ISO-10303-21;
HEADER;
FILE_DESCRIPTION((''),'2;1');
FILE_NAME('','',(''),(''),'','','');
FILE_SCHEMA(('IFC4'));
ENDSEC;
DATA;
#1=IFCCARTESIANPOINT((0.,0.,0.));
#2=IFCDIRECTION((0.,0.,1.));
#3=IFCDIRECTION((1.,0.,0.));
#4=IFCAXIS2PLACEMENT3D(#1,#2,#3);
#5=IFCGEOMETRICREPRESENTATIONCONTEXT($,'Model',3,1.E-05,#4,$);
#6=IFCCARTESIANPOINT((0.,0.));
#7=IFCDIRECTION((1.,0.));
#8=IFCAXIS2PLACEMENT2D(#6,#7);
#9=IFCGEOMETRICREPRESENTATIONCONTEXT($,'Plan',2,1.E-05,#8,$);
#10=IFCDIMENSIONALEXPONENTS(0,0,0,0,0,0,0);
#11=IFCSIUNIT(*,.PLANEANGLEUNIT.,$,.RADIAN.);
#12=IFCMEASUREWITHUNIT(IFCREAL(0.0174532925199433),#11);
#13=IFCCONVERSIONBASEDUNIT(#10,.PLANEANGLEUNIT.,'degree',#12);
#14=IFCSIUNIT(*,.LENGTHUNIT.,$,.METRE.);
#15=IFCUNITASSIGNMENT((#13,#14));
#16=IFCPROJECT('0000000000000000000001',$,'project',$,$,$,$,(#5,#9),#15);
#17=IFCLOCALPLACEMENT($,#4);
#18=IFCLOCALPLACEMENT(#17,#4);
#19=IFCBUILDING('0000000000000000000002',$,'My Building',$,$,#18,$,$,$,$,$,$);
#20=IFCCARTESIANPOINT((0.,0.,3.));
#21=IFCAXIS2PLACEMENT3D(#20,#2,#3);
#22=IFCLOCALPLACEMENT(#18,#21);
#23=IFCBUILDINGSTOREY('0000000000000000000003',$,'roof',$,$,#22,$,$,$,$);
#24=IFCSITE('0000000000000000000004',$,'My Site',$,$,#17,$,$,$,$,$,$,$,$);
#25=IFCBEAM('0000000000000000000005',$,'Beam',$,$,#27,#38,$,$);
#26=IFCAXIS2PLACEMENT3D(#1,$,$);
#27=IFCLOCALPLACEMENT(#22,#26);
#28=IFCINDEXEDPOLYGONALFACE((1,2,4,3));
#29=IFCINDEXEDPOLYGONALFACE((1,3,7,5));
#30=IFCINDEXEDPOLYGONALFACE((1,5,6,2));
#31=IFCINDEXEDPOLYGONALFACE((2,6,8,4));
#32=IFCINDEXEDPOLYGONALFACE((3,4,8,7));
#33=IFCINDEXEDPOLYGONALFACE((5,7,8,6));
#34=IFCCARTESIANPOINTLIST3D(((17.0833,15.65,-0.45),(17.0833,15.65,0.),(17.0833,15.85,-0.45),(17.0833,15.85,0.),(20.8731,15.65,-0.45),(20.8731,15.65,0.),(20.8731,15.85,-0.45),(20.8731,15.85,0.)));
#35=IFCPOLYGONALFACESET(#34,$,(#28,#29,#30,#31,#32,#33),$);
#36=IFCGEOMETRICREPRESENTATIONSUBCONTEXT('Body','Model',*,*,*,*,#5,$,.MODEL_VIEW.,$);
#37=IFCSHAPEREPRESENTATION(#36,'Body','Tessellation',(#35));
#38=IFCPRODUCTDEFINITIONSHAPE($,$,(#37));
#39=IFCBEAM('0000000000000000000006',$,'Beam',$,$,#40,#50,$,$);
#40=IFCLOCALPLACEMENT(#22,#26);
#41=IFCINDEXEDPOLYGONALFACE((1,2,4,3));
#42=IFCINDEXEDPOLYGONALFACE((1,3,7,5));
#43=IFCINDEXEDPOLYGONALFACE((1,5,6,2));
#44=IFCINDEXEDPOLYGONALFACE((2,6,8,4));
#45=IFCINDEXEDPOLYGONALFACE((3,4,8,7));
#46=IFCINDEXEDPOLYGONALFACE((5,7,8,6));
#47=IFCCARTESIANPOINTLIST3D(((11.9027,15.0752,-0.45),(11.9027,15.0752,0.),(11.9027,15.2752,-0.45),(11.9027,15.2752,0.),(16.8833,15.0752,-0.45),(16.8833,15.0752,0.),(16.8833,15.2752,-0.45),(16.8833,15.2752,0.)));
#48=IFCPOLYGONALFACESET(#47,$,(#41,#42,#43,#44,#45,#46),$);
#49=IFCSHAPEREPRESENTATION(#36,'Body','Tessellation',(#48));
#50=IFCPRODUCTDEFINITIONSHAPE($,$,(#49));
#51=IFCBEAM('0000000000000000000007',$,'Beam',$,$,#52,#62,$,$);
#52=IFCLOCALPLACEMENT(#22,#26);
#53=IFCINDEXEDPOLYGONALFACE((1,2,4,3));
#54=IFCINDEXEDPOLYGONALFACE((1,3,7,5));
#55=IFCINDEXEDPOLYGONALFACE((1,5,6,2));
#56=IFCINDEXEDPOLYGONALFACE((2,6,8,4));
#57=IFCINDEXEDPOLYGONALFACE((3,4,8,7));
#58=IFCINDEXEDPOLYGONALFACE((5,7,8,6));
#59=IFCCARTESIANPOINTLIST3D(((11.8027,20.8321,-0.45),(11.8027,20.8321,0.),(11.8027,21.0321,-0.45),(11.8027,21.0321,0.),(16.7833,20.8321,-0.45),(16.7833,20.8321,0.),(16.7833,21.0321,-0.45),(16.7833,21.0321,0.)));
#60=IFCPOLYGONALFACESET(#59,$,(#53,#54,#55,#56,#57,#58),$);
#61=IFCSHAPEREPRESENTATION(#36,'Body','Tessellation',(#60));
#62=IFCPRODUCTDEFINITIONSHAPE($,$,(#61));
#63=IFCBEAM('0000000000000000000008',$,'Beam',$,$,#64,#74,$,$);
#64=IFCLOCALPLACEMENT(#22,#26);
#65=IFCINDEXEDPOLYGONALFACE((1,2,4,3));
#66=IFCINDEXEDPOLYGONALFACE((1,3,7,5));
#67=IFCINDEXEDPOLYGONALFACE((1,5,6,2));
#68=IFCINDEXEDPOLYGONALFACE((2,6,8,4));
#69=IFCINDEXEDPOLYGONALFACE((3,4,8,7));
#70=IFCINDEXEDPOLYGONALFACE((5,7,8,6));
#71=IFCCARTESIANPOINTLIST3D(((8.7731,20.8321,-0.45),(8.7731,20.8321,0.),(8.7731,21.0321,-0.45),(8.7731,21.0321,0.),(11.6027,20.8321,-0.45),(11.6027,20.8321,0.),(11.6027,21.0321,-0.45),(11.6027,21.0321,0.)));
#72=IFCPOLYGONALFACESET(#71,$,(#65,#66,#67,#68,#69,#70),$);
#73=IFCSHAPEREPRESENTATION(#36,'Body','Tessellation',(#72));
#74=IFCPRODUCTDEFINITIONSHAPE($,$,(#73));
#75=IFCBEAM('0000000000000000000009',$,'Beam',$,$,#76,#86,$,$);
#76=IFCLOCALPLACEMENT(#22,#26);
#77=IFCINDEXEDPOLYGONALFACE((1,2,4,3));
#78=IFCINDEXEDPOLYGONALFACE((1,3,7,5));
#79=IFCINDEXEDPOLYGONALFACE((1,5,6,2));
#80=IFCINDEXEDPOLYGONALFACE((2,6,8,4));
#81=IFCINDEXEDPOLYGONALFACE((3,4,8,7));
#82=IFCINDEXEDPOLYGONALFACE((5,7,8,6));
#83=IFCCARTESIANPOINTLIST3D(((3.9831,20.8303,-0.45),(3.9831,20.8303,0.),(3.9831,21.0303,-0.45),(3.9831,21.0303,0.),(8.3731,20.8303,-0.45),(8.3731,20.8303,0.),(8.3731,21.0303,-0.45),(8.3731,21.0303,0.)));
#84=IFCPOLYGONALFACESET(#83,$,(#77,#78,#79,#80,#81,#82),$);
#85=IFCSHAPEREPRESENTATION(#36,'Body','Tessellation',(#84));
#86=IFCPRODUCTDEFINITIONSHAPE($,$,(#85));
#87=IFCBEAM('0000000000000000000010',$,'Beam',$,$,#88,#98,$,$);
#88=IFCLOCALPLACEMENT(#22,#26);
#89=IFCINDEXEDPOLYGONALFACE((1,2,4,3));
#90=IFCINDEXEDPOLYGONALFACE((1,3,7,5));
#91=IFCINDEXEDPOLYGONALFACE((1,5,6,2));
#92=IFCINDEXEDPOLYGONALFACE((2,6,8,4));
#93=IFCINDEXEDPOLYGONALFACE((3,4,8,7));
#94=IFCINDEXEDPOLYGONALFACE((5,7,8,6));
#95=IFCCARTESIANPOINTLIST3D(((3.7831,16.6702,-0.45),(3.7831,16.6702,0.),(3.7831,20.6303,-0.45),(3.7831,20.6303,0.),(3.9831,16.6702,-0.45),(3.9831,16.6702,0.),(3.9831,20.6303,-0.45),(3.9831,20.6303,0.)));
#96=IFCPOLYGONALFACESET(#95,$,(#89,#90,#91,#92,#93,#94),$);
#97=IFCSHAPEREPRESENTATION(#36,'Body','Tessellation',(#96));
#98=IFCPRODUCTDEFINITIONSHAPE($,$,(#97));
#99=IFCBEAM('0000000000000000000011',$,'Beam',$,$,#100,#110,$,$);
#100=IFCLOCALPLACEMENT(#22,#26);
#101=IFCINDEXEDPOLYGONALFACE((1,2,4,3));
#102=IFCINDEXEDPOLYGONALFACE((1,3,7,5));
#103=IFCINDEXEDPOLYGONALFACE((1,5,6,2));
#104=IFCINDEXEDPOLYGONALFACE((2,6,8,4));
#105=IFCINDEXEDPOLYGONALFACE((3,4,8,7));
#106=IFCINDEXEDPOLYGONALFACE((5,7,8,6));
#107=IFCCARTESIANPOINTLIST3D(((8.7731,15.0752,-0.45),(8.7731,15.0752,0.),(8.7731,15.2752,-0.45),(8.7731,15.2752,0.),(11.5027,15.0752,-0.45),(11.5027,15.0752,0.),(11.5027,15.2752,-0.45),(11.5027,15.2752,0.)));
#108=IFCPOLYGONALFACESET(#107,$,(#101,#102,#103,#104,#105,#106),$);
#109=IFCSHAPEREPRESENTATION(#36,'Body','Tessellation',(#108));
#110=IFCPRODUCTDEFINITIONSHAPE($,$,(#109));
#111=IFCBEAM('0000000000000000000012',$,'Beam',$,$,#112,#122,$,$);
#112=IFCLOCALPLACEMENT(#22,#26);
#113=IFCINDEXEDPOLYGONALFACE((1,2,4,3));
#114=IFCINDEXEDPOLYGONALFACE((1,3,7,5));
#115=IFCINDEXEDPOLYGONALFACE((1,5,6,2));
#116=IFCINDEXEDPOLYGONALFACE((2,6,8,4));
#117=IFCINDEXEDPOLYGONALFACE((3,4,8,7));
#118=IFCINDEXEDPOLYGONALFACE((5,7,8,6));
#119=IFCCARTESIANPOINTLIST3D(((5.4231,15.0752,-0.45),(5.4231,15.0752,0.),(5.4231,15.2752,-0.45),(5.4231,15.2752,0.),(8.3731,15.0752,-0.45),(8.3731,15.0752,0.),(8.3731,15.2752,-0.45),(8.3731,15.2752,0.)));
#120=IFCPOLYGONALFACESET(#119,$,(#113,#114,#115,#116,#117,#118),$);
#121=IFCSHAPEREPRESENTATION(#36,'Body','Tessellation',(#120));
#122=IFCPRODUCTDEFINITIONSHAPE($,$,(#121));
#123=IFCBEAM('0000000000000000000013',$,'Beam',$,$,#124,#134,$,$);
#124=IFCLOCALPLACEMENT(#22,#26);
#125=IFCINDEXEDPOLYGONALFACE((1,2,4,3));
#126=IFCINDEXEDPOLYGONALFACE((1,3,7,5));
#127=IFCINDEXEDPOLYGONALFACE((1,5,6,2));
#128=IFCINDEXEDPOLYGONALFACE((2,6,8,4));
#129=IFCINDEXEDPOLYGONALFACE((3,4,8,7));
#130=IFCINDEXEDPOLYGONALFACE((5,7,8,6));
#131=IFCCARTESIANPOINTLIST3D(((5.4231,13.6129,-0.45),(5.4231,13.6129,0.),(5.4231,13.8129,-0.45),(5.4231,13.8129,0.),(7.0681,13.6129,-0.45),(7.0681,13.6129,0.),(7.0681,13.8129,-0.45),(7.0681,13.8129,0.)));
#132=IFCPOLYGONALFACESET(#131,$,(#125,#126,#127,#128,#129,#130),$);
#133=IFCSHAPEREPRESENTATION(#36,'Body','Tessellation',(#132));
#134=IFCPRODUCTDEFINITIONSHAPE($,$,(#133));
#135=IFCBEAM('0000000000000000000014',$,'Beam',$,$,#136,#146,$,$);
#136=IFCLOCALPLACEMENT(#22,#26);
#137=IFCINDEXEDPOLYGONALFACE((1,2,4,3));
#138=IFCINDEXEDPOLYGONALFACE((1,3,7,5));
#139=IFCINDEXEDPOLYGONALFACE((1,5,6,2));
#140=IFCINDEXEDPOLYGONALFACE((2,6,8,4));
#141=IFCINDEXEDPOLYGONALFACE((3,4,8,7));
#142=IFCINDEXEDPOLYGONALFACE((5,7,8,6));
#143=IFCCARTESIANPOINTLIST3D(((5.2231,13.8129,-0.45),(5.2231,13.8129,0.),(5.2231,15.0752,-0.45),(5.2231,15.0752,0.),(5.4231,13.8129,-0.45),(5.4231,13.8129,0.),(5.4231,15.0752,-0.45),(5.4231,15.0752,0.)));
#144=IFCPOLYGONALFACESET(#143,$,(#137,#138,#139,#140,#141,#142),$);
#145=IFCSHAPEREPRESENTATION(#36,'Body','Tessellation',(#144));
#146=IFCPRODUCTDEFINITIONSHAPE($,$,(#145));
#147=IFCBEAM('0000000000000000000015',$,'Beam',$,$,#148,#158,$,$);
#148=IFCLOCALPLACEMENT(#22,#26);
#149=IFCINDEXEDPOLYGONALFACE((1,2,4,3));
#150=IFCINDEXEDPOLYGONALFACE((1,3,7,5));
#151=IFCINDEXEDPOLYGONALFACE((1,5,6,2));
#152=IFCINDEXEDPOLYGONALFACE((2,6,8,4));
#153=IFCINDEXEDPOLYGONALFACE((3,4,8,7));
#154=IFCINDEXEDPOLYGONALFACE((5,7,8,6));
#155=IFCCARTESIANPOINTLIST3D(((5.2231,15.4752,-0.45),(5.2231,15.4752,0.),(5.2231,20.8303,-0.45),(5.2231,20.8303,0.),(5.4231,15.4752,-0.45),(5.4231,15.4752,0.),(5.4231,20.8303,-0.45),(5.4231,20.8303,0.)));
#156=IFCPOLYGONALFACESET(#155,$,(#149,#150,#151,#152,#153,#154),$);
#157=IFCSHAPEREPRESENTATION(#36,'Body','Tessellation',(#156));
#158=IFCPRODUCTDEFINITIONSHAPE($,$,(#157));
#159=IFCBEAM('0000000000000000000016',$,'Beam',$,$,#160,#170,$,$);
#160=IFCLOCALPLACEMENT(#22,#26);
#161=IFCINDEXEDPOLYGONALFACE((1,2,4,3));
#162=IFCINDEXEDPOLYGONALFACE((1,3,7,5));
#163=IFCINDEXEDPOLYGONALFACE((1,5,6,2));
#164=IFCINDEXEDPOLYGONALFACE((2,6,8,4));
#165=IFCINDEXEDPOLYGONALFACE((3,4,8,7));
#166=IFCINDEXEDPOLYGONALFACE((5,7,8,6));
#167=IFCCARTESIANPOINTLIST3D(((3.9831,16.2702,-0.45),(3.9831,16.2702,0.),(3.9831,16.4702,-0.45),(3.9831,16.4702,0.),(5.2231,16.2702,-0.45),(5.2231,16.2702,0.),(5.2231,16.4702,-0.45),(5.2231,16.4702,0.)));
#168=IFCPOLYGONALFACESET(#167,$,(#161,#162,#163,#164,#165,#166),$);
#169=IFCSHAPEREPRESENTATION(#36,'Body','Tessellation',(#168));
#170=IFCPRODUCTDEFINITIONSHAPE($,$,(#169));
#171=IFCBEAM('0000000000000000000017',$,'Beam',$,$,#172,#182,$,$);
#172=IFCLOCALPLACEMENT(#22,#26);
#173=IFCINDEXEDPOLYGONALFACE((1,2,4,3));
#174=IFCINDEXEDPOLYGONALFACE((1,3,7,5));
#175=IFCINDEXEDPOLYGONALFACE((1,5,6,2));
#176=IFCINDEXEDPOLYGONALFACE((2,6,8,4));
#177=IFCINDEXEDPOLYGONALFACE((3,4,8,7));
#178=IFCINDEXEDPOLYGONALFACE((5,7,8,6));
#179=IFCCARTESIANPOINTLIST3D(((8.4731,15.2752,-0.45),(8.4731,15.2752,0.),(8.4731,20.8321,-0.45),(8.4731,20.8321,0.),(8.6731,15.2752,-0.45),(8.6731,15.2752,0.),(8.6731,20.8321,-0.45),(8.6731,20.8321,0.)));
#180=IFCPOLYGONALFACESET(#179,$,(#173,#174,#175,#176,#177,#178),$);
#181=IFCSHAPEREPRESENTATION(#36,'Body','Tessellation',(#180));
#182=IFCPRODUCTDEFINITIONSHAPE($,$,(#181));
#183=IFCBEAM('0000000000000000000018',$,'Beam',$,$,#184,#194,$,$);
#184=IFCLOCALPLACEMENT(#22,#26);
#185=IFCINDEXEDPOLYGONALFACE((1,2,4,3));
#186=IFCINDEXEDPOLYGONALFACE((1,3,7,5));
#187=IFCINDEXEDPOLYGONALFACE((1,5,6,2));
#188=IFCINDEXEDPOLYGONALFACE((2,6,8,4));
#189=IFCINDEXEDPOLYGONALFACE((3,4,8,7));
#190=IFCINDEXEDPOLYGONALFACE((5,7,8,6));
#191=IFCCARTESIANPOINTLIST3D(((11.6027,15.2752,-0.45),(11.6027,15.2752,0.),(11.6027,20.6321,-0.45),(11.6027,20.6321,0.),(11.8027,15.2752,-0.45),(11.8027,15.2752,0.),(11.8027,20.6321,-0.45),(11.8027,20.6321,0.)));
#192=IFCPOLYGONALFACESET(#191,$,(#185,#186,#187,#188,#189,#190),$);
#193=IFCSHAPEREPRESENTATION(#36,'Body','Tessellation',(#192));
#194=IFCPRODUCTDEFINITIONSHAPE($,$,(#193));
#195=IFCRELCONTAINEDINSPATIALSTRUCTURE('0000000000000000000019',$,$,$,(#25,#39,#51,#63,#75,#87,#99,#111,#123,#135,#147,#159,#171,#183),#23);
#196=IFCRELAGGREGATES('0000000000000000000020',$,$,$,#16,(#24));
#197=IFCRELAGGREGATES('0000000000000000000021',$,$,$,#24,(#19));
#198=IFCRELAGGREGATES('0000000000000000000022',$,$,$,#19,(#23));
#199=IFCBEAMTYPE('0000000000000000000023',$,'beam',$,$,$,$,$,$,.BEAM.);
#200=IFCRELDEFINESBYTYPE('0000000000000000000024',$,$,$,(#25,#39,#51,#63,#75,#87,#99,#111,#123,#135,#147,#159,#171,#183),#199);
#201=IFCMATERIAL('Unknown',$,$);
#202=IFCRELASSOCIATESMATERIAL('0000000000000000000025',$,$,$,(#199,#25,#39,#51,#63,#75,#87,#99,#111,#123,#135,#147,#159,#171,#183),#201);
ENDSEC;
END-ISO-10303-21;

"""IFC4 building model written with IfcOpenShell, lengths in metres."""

from ifc_helpers import new_model, entity, si_unit, converted_unit, frame, origin_with_axes, origin_2d_with_axis, place, context, subcontext, project, spatial, rectangle, extrude, material, material_profile, profile_set, profile_usage, type_object, element, save


model = new_model("IFC4")

# Units and contexts
model_context = context("Model", 3, precision=1e-05, world=origin_with_axes())
plan_context = context("Plan", 2, precision=1e-05, world=origin_2d_with_axis())
body_context = subcontext(model_context, "Body", "Model", "MODEL_VIEW")
ifc_project = project(units=[converted_unit("PLANEANGLEUNIT", "degree", entity("IfcReal", 0.0174532925199433), si_unit("PLANEANGLEUNIT", "RADIAN"), dimensions=[0, 0, 0, 0, 0, 0, 0]), si_unit("LENGTHUNIT", "METRE")], contexts=[model_context, plan_context])

# Site, building, storey
site_placement = place(None, origin_with_axes())
site = spatial("IfcSite", under=ifc_project, at=site_placement, Name="My Site")
building_placement = place(site_placement, origin_with_axes())
building = spatial("IfcBuilding", under=site, at=building_placement, Name="My Building")
storey_placement = place(building_placement, frame((0.0, 0.0, 3.0), z_axis=(0.0, 0.0, 1.0), x_axis=(1.0, 0.0, 0.0)))
storey = spatial("IfcBuildingStorey", under=building, at=storey_placement, Name="roof")

# Beams
ifc_material = material(Name="Unknown")
ifc_material_profile = material_profile(ifc_material, rectangle(XDim=0.2, YDim=0.45))
ifc_profile_set = profile_set([ifc_material_profile])
beam_type = type_object("IfcBeamType", Name="beam", PredefinedType="BEAM", material=ifc_profile_set)
ifc_profile_usage_1 = profile_usage(ifc_profile_set, cardinal=9)
beam_1_placement = place(storey_placement, frame((17.0833, 15.65, 0.0), z_axis=(1.0, 0.0, 0.0), x_axis=(0.0, 1.0, 0.0)))
element("IfcBeam", 1, at=beam_1_placement, inside=storey, type_object=beam_type, material=ifc_profile_usage_1, Name="Beam", context=body_context, shape_type="SweptSolid", body=[
    extrude(rectangle(XDim=0.2, YDim=0.45), frame((0.1, -0.225, 0.0), z_axis=(0.0, 0.0, 1.0), x_axis=(1.0, 0.0, 0.0)), (0.0, 0.0, 1.0), 3.7898),
])
ifc_profile_usage_2 = profile_usage(ifc_profile_set, cardinal=9)
beam_2_placement = place(storey_placement, frame((11.9027, 15.0752, 0.0), z_axis=(1.0, 0.0, 0.0), x_axis=(0.0, 1.0, 0.0)))
element("IfcBeam", 2, at=beam_2_placement, inside=storey, type_object=beam_type, material=ifc_profile_usage_2, Name="Beam", context=body_context, shape_type="SweptSolid", body=[
    extrude(rectangle(XDim=0.2, YDim=0.45), frame((0.1, -0.225, 0.0), z_axis=(0.0, 0.0, 1.0), x_axis=(1.0, 0.0, 0.0)), (0.0, 0.0, 1.0), 4.9806),
])
ifc_profile_usage_3 = profile_usage(ifc_profile_set, cardinal=9)
beam_3_placement = place(storey_placement, frame((11.8027, 20.8321, 0.0), z_axis=(1.0, 0.0, 0.0), x_axis=(0.0, 1.0, 0.0)))
element("IfcBeam", 3, at=beam_3_placement, inside=storey, type_object=beam_type, material=ifc_profile_usage_3, Name="Beam", context=body_context, shape_type="SweptSolid", body=[
    extrude(rectangle(XDim=0.2, YDim=0.45), frame((0.1, -0.225, 0.0), z_axis=(0.0, 0.0, 1.0), x_axis=(1.0, 0.0, 0.0)), (0.0, 0.0, 1.0), 4.9806),
])
ifc_profile_usage_4 = profile_usage(ifc_profile_set, cardinal=9)
beam_4_placement = place(storey_placement, frame((11.6027, 21.0321, 0.0), z_axis=(-1.0, 0.000001, 0.0), x_axis=(-0.000001, -1.0, 0.0)))
element("IfcBeam", 4, at=beam_4_placement, inside=storey, type_object=beam_type, material=ifc_profile_usage_4, Name="Beam", context=body_context, shape_type="SweptSolid", body=[
    extrude(rectangle(XDim=0.2, YDim=0.45), frame((0.1, -0.225, 0.0), z_axis=(0.0, 0.0, 1.0), x_axis=(1.0, 0.0, 0.0)), (0.0, 0.0, 1.0), 2.8295),
])
ifc_profile_usage_5 = profile_usage(ifc_profile_set, cardinal=9)
beam_5_placement = place(storey_placement, frame((8.3731, 21.0303, 0.0), z_axis=(-1.0, 0.000001, 0.0), x_axis=(-0.000001, -1.0, 0.0)))
element("IfcBeam", 5, at=beam_5_placement, inside=storey, type_object=beam_type, material=ifc_profile_usage_5, Name="Beam", context=body_context, shape_type="SweptSolid", body=[
    extrude(rectangle(XDim=0.2, YDim=0.45), frame((0.1, -0.225, 0.0), z_axis=(0.0, 0.0, 1.0), x_axis=(1.0, 0.0, 0.0)), (0.0, 0.0, 1.0), 4.39),
])
ifc_profile_usage_6 = profile_usage(ifc_profile_set, cardinal=9)
beam_6_placement = place(storey_placement, frame((3.7831, 20.6303, 0.0), z_axis=(0.0, -1.0, 0.0), x_axis=(1.0, 0.0, 0.0)))
element("IfcBeam", 6, at=beam_6_placement, inside=storey, type_object=beam_type, material=ifc_profile_usage_6, Name="Beam", context=body_context, shape_type="SweptSolid", body=[
    extrude(rectangle(XDim=0.2, YDim=0.45), frame((0.1, -0.225, 0.0), z_axis=(0.0, 0.0, 1.0), x_axis=(1.0, 0.0, 0.0)), (0.0, 0.0, 1.0), 3.9601),
])
ifc_profile_usage_7 = profile_usage(ifc_profile_set, cardinal=9)
beam_7_placement = place(storey_placement, frame((11.5027, 15.2752, 0.0), z_axis=(-1.0, 0.000001, 0.0), x_axis=(-0.000001, -1.0, 0.0)))
element("IfcBeam", 7, at=beam_7_placement, inside=storey, type_object=beam_type, material=ifc_profile_usage_7, Name="Beam", context=body_context, shape_type="SweptSolid", body=[
    extrude(rectangle(XDim=0.2, YDim=0.45), frame((0.1, -0.225, 0.0), z_axis=(0.0, 0.0, 1.0), x_axis=(1.0, 0.0, 0.0)), (0.0, 0.0, 1.0), 2.7295),
])
ifc_profile_usage_8 = profile_usage(ifc_profile_set, cardinal=9)
beam_8_placement = place(storey_placement, frame((8.3731, 15.2752, 0.0), z_axis=(-1.0, 0.000001, 0.0), x_axis=(-0.000001, -1.0, 0.0)))
element("IfcBeam", 8, at=beam_8_placement, inside=storey, type_object=beam_type, material=ifc_profile_usage_8, Name="Beam", context=body_context, shape_type="SweptSolid", body=[
    extrude(rectangle(XDim=0.2, YDim=0.45), frame((0.1, -0.225, 0.0), z_axis=(0.0, 0.0, 1.0), x_axis=(1.0, 0.0, 0.0)), (0.0, 0.0, 1.0), 2.95),
])
ifc_profile_usage_9 = profile_usage(ifc_profile_set, cardinal=9)
beam_9_placement = place(storey_placement, frame((5.4231, 13.6129, 0.0), z_axis=(1.0, 0.0, 0.0), x_axis=(0.0, 1.0, 0.0)))
element("IfcBeam", 9, at=beam_9_placement, inside=storey, type_object=beam_type, material=ifc_profile_usage_9, Name="Beam", context=body_context, shape_type="SweptSolid", body=[
    extrude(rectangle(XDim=0.2, YDim=0.45), frame((0.1, -0.225, 0.0), z_axis=(0.0, 0.0, 1.0), x_axis=(1.0, 0.0, 0.0)), (0.0, 0.0, 1.0), 1.645),
])
ifc_profile_usage_10 = profile_usage(ifc_profile_set, cardinal=9)
beam_10_placement = place(storey_placement, frame((5.2231, 15.0752, 0.0), z_axis=(-0.000001, -1.0, 0.0), x_axis=(1.0, -0.000001, 0.0)))
element("IfcBeam", 10, at=beam_10_placement, inside=storey, type_object=beam_type, material=ifc_profile_usage_10, Name="Beam", context=body_context, shape_type="SweptSolid", body=[
    extrude(rectangle(XDim=0.2, YDim=0.45), frame((0.1, -0.225, 0.0), z_axis=(0.0, 0.0, 1.0), x_axis=(1.0, 0.0, 0.0)), (0.0, 0.0, 1.0), 1.2623),
])
ifc_profile_usage_11 = profile_usage(ifc_profile_set, cardinal=9)
beam_11_placement = place(storey_placement, frame((5.2231, 20.8303, 0.0), z_axis=(-0.000001, -1.0, 0.0), x_axis=(1.0, -0.000001, 0.0)))
element("IfcBeam", 11, at=beam_11_placement, inside=storey, type_object=beam_type, material=ifc_profile_usage_11, Name="Beam", context=body_context, shape_type="SweptSolid", body=[
    extrude(rectangle(XDim=0.2, YDim=0.45), frame((0.1, -0.225, 0.0), z_axis=(0.0, 0.0, 1.0), x_axis=(1.0, 0.0, 0.0)), (0.0, 0.0, 1.0), 5.3551),
])
ifc_profile_usage_12 = profile_usage(ifc_profile_set, cardinal=9)
beam_12_placement = place(storey_placement, frame((3.9831, 16.2702, 0.0), z_axis=(1.0, 0.0, 0.0), x_axis=(0.0, 1.0, 0.0)))
element("IfcBeam", 12, at=beam_12_placement, inside=storey, type_object=beam_type, material=ifc_profile_usage_12, Name="Beam", context=body_context, shape_type="SweptSolid", body=[
    extrude(rectangle(XDim=0.2, YDim=0.45), frame((0.1, -0.225, 0.0), z_axis=(0.0, 0.0, 1.0), x_axis=(1.0, 0.0, 0.0)), (0.0, 0.0, 1.0), 1.24),
])
ifc_profile_usage_13 = profile_usage(ifc_profile_set, cardinal=9)
beam_13_placement = place(storey_placement, frame((8.4731, 20.8321, 0.0), z_axis=(-0.000001, -1.0, 0.0), x_axis=(1.0, -0.000001, 0.0)))
element("IfcBeam", 13, at=beam_13_placement, inside=storey, type_object=beam_type, material=ifc_profile_usage_13, Name="Beam", context=body_context, shape_type="SweptSolid", body=[
    extrude(rectangle(XDim=0.2, YDim=0.45), frame((0.1, -0.225, 0.0), z_axis=(0.0, 0.0, 1.0), x_axis=(1.0, 0.0, 0.0)), (0.0, 0.0, 1.0), 5.5569),
])
ifc_profile_usage_14 = profile_usage(ifc_profile_set, cardinal=9)
beam_14_placement = place(storey_placement, frame((11.6027, 20.6321, 0.0), z_axis=(-0.000001, -1.0, 0.0), x_axis=(1.0, -0.000001, 0.0)))
element("IfcBeam", 14, at=beam_14_placement, inside=storey, type_object=beam_type, material=ifc_profile_usage_14, Name="Beam", context=body_context, shape_type="SweptSolid", body=[
    extrude(rectangle(XDim=0.2, YDim=0.45), frame((0.1, -0.225, 0.0), z_axis=(0.0, 0.0, 1.0), x_axis=(1.0, 0.0, 0.0)), (0.0, 0.0, 1.0), 5.3569),
])

save(model, "model.ifc")
